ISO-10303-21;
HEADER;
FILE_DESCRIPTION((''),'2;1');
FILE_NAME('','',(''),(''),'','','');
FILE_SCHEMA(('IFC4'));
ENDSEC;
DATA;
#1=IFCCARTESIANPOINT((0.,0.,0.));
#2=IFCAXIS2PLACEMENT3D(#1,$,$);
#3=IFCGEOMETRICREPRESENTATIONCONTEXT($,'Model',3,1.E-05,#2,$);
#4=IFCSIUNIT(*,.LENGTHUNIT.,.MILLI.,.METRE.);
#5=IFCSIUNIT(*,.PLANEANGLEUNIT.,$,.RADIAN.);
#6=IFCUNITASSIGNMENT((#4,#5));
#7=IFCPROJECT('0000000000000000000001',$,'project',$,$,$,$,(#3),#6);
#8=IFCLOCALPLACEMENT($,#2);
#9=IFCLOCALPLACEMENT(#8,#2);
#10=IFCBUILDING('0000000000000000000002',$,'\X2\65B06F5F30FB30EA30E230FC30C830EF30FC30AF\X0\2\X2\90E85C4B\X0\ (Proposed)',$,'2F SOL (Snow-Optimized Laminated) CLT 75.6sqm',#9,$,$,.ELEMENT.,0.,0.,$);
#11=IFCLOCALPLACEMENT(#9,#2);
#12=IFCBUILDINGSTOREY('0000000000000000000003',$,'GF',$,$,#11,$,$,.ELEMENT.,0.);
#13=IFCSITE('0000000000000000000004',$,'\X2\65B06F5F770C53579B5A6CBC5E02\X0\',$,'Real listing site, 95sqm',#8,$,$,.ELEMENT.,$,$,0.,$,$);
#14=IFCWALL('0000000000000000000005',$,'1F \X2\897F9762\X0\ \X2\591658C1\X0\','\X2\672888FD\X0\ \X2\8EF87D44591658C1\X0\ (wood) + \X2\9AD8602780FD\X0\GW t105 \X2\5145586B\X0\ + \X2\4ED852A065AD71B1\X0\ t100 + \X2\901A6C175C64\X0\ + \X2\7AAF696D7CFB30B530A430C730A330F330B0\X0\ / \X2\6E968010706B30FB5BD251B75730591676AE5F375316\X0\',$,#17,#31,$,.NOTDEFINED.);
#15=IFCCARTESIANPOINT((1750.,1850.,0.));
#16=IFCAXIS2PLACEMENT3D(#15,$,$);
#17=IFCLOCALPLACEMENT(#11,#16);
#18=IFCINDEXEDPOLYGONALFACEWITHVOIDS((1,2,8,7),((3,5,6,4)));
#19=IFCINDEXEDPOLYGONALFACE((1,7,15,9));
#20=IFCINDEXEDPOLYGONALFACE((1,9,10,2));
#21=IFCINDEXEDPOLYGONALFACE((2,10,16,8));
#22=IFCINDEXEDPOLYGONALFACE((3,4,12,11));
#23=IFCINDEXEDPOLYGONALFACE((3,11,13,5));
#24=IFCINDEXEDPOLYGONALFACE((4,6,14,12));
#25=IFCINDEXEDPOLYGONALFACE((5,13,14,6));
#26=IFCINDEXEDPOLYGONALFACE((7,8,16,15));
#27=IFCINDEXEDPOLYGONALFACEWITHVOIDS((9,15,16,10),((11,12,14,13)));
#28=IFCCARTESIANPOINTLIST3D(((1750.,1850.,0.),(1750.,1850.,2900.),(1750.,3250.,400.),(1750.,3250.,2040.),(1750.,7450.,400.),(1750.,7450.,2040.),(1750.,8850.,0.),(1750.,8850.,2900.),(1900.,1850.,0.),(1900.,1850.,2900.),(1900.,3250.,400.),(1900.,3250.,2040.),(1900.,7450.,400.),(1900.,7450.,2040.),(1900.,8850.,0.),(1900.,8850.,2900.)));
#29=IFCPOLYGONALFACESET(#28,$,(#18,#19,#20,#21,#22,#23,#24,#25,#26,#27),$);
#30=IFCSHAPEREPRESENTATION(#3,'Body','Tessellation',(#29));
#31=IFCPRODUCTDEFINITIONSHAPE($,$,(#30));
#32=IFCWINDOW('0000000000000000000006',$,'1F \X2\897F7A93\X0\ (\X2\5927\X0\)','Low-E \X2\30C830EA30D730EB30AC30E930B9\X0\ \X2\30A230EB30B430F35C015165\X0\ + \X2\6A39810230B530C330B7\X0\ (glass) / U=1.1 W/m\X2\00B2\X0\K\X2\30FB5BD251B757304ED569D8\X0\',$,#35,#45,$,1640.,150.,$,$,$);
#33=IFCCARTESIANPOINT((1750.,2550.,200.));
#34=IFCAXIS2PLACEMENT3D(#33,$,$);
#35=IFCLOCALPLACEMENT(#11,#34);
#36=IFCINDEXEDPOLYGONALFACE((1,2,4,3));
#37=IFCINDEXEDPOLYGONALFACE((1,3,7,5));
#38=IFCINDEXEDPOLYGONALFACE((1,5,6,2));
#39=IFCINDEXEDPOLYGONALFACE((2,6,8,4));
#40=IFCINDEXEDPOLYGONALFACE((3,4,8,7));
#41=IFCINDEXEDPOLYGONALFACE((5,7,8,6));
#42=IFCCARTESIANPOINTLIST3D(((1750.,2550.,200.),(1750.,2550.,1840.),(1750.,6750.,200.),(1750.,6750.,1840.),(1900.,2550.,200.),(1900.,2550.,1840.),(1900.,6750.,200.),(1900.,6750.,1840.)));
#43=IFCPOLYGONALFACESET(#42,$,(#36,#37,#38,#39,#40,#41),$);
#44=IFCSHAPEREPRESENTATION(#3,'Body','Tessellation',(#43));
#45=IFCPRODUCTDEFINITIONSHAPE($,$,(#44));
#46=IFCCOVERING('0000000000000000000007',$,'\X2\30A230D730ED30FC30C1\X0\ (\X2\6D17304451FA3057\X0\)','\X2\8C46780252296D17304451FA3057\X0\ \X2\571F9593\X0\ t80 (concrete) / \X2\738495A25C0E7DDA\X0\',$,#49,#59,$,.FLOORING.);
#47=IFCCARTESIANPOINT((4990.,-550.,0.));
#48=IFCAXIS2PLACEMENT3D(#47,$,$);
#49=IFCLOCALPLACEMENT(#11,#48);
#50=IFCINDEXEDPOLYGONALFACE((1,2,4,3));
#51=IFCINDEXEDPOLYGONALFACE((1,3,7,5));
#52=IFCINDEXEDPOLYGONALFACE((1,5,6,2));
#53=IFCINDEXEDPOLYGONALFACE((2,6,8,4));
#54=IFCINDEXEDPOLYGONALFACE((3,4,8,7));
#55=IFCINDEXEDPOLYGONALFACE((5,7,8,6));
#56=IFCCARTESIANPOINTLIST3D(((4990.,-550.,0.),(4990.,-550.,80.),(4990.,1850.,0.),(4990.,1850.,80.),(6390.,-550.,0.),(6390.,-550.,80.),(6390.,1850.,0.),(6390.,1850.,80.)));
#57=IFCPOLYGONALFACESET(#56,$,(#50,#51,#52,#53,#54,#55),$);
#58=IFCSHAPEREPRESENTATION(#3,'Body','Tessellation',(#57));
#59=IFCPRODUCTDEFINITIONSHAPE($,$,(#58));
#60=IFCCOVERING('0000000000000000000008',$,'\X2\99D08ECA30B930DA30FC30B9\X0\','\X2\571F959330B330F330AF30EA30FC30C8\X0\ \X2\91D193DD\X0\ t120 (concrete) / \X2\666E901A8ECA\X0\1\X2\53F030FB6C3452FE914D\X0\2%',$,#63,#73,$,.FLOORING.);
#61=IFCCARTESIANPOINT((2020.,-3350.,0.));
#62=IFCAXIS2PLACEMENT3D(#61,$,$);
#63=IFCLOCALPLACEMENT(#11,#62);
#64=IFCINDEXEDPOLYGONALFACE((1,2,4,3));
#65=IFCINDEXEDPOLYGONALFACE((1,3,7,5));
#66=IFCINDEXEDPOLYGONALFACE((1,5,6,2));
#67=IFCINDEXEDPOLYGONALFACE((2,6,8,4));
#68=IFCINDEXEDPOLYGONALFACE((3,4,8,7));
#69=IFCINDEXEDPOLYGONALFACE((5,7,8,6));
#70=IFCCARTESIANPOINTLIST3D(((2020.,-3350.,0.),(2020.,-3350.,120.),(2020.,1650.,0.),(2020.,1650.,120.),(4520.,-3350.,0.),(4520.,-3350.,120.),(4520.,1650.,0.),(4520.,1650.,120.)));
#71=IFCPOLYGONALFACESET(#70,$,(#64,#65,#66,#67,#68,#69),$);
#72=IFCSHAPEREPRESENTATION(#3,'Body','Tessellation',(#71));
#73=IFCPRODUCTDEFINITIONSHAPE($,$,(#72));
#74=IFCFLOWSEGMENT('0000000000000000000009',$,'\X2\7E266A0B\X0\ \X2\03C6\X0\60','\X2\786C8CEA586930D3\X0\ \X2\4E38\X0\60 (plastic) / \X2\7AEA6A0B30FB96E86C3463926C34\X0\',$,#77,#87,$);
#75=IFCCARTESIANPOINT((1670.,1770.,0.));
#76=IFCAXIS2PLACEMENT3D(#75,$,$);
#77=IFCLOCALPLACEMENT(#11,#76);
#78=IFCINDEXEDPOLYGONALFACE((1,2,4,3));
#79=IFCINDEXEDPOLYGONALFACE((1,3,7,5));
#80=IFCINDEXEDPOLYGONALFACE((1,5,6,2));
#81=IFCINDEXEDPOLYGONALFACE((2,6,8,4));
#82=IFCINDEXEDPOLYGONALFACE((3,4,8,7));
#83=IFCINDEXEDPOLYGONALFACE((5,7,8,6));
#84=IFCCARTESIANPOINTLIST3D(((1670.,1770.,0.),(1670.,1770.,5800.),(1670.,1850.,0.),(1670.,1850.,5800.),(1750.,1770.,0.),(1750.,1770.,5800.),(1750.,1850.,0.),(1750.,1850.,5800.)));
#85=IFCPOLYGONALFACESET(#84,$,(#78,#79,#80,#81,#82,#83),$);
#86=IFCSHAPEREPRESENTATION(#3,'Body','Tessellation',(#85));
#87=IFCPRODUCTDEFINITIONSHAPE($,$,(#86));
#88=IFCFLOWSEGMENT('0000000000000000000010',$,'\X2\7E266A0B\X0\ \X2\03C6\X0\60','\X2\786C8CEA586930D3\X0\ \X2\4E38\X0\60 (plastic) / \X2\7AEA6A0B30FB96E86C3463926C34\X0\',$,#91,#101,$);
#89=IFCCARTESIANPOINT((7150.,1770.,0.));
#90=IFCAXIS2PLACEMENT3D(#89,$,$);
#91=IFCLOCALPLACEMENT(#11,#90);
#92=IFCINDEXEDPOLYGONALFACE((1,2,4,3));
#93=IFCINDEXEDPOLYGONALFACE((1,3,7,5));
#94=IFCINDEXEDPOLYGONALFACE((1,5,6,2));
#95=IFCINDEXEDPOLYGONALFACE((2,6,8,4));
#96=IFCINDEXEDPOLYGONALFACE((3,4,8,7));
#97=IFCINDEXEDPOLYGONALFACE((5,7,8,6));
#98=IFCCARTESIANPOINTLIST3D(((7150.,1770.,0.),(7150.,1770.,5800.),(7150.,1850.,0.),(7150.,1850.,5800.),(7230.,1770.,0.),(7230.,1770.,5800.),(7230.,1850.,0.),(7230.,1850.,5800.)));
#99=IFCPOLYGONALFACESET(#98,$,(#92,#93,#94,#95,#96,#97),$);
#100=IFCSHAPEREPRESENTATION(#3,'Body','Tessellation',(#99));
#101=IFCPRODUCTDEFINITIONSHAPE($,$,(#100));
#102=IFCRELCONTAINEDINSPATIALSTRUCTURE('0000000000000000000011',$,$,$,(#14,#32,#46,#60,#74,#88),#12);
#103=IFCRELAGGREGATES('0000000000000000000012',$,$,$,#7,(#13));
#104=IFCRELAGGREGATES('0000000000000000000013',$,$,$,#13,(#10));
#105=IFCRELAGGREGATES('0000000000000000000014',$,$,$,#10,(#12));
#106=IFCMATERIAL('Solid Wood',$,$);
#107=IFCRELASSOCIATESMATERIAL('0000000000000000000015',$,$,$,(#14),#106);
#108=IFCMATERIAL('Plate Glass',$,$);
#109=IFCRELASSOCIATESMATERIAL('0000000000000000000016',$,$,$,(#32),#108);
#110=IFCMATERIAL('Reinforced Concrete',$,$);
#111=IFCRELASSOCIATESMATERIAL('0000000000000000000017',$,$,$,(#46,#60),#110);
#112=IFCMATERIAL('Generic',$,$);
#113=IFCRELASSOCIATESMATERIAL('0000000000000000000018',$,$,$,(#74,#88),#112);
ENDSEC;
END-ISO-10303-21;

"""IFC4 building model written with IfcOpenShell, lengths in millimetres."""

from ifc_helpers import new_model, si_unit, frame, frame_2d, origin, place, context, project, spatial, rectangle, extrude, material, element, fill, save


model = new_model("IFC4")

# Units and contexts
model_context = context("Model", 3, precision=1e-05, world=origin())
ifc_project = project(units=[si_unit("LENGTHUNIT", "METRE", prefix="MILLI"), si_unit("PLANEANGLEUNIT", "RADIAN")], contexts=[model_context])

# Site, building, storey
site_placement = place(None, origin())
site = spatial("IfcSite", under=ifc_project, at=site_placement, Name="新潟県南魚沼市", ObjectType="Real listing site, 95sqm", CompositionType="ELEMENT", RefElevation=0.0)
building_placement = place(site_placement, origin())
building = spatial("IfcBuilding", under=site, at=building_placement, Name="新潟・リモートワーク2部屋 (Proposed)", ObjectType="2F SOL (Snow-Optimized Laminated) CLT 75.6sqm", CompositionType="ELEMENT", ElevationOfRefHeight=0.0, ElevationOfTerrain=0.0)
storey_placement = place(building_placement, origin())
storey = spatial("IfcBuildingStorey", under=building, at=storey_placement, Name="GF", CompositionType="ELEMENT", Elevation=0.0)

# Shared definitions
ifc_material_1 = material(Name="Solid Wood")

# Shared definitions
ifc_material_2 = material(Name="Reinforced Concrete")

# Shared definitions
ifc_material_3 = material(Name="Plate Glass")

# Wall, opening, window
wall_1_placement = place(storey_placement, frame((1750.0, 1850.0, 0.0)))
wall_1 = element("IfcWall", 1, at=wall_1_placement, inside=storey, material=ifc_material_1, Name="1F 西面 外壁", Description="木製 軸組外壁 (wood) + 高性能GW t105 充填 + 付加断熱 t100 + 通気層 + 窯業系サイディング / 準耐火・寒冷地外皮強化", PredefinedType="NOTDEFINED", context=model_context, shape_type="SweptSolid", body=[
    extrude(rectangle(XDim=150.0, YDim=7000.0, at=frame_2d((75.0, 3500.0))), frame((1750.0, 1850.0, 0.0)), (0.0, 0.0, 1.0), 2900.0),
])
opening_1_placement = place(storey_placement, frame((1750.0, 2550.0, 200.0)))
opening_1 = element("IfcOpeningElement", 2, at=opening_1_placement, cuts=wall_1, PredefinedType="NOTDEFINED", context=model_context, shape_type="SweptSolid", body=[
    extrude(rectangle(XDim=150.0, YDim=4200.0, at=frame_2d((75.0, 2100.0))), frame((1750.0, 2550.0, 200.0)), (0.0, 0.0, 1.0), 1640.0),
])
window_1_placement = place(storey_placement, frame((1750.0, 2550.0, 200.0)))
window_1 = element("IfcWindow", 3, at=window_1_placement, inside=storey, material=ifc_material_3, Name="1F 西窓 (大)", Description="Low-E トリプルガラス アルゴン封入 + 樹脂サッシ (glass) / U=1.1 W/m²K・寒冷地仕様", OverallHeight=1640.0, OverallWidth=150.0, context=model_context, shape_type="SweptSolid", body=[
    extrude(rectangle(XDim=150.0, YDim=4200.0, at=frame_2d((75.0, 2100.0))), frame((1750.0, 2550.0, 200.0)), (0.0, 0.0, 1.0), 1640.0),
])
fill(opening_1, window_1)

# Coverings
covering_1_placement = place(storey_placement, frame((4990.0, -550.0, 0.0)))
element("IfcCovering", 4, at=covering_1_placement, inside=storey, material=ifc_material_2, Name="アプローチ (洗い出し)", Description="豆砂利洗い出し 土間 t80 (concrete) / 玄関導線", PredefinedType="FLOORING", context=model_context, shape_type="SweptSolid", body=[
    extrude(rectangle(XDim=1400.0, YDim=2400.0, at=frame_2d((700.0, 1200.0))), frame((4990.0, -550.0, 0.0)), (0.0, 0.0, 1.0), 80.0),
])
covering_2_placement = place(storey_placement, frame((2020.0, -3350.0, 0.0)))
element("IfcCovering", 5, at=covering_2_placement, inside=storey, material=ifc_material_2, Name="駐車スペース", Description="土間コンクリート 金鏝 t120 (concrete) / 普通車1台・水勾配2%", PredefinedType="FLOORING", context=model_context, shape_type="SweptSolid", body=[
    extrude(rectangle(XDim=2500.0, YDim=5000.0, at=frame_2d((1250.0, 2500.0))), frame((2020.0, -3350.0, 0.0)), (0.0, 0.0, 1.0), 120.0),
])

# Flow segments
ifc_material_4 = material(Name="Generic")
flow_segment_1_placement = place(storey_placement, frame((1670.0, 1770.0, 0.0)))
element("IfcFlowSegment", 6, at=flow_segment_1_placement, inside=storey, material=ifc_material_4, Name="縦樋 φ60", Description="硬質塩ビ 丸60 (plastic) / 竪樋・雨水排水", context=model_context, shape_type="SweptSolid", body=[
    extrude(rectangle(XDim=80.0, YDim=80.0, at=frame_2d((40.0, 40.0))), frame((1670.0, 1770.0, 0.0)), (0.0, 0.0, 1.0), 5800.0),
])
flow_segment_2_placement = place(storey_placement, frame((7150.0, 1770.0, 0.0)))
element("IfcFlowSegment", 7, at=flow_segment_2_placement, inside=storey, material=ifc_material_4, Name="縦樋 φ60", Description="硬質塩ビ 丸60 (plastic) / 竪樋・雨水排水", context=model_context, shape_type="SweptSolid", body=[
    extrude(rectangle(XDim=80.0, YDim=80.0, at=frame_2d((40.0, 40.0))), frame((7150.0, 1770.0, 0.0)), (0.0, 0.0, 1.0), 5800.0),
])

save(model, "model.ifc")
